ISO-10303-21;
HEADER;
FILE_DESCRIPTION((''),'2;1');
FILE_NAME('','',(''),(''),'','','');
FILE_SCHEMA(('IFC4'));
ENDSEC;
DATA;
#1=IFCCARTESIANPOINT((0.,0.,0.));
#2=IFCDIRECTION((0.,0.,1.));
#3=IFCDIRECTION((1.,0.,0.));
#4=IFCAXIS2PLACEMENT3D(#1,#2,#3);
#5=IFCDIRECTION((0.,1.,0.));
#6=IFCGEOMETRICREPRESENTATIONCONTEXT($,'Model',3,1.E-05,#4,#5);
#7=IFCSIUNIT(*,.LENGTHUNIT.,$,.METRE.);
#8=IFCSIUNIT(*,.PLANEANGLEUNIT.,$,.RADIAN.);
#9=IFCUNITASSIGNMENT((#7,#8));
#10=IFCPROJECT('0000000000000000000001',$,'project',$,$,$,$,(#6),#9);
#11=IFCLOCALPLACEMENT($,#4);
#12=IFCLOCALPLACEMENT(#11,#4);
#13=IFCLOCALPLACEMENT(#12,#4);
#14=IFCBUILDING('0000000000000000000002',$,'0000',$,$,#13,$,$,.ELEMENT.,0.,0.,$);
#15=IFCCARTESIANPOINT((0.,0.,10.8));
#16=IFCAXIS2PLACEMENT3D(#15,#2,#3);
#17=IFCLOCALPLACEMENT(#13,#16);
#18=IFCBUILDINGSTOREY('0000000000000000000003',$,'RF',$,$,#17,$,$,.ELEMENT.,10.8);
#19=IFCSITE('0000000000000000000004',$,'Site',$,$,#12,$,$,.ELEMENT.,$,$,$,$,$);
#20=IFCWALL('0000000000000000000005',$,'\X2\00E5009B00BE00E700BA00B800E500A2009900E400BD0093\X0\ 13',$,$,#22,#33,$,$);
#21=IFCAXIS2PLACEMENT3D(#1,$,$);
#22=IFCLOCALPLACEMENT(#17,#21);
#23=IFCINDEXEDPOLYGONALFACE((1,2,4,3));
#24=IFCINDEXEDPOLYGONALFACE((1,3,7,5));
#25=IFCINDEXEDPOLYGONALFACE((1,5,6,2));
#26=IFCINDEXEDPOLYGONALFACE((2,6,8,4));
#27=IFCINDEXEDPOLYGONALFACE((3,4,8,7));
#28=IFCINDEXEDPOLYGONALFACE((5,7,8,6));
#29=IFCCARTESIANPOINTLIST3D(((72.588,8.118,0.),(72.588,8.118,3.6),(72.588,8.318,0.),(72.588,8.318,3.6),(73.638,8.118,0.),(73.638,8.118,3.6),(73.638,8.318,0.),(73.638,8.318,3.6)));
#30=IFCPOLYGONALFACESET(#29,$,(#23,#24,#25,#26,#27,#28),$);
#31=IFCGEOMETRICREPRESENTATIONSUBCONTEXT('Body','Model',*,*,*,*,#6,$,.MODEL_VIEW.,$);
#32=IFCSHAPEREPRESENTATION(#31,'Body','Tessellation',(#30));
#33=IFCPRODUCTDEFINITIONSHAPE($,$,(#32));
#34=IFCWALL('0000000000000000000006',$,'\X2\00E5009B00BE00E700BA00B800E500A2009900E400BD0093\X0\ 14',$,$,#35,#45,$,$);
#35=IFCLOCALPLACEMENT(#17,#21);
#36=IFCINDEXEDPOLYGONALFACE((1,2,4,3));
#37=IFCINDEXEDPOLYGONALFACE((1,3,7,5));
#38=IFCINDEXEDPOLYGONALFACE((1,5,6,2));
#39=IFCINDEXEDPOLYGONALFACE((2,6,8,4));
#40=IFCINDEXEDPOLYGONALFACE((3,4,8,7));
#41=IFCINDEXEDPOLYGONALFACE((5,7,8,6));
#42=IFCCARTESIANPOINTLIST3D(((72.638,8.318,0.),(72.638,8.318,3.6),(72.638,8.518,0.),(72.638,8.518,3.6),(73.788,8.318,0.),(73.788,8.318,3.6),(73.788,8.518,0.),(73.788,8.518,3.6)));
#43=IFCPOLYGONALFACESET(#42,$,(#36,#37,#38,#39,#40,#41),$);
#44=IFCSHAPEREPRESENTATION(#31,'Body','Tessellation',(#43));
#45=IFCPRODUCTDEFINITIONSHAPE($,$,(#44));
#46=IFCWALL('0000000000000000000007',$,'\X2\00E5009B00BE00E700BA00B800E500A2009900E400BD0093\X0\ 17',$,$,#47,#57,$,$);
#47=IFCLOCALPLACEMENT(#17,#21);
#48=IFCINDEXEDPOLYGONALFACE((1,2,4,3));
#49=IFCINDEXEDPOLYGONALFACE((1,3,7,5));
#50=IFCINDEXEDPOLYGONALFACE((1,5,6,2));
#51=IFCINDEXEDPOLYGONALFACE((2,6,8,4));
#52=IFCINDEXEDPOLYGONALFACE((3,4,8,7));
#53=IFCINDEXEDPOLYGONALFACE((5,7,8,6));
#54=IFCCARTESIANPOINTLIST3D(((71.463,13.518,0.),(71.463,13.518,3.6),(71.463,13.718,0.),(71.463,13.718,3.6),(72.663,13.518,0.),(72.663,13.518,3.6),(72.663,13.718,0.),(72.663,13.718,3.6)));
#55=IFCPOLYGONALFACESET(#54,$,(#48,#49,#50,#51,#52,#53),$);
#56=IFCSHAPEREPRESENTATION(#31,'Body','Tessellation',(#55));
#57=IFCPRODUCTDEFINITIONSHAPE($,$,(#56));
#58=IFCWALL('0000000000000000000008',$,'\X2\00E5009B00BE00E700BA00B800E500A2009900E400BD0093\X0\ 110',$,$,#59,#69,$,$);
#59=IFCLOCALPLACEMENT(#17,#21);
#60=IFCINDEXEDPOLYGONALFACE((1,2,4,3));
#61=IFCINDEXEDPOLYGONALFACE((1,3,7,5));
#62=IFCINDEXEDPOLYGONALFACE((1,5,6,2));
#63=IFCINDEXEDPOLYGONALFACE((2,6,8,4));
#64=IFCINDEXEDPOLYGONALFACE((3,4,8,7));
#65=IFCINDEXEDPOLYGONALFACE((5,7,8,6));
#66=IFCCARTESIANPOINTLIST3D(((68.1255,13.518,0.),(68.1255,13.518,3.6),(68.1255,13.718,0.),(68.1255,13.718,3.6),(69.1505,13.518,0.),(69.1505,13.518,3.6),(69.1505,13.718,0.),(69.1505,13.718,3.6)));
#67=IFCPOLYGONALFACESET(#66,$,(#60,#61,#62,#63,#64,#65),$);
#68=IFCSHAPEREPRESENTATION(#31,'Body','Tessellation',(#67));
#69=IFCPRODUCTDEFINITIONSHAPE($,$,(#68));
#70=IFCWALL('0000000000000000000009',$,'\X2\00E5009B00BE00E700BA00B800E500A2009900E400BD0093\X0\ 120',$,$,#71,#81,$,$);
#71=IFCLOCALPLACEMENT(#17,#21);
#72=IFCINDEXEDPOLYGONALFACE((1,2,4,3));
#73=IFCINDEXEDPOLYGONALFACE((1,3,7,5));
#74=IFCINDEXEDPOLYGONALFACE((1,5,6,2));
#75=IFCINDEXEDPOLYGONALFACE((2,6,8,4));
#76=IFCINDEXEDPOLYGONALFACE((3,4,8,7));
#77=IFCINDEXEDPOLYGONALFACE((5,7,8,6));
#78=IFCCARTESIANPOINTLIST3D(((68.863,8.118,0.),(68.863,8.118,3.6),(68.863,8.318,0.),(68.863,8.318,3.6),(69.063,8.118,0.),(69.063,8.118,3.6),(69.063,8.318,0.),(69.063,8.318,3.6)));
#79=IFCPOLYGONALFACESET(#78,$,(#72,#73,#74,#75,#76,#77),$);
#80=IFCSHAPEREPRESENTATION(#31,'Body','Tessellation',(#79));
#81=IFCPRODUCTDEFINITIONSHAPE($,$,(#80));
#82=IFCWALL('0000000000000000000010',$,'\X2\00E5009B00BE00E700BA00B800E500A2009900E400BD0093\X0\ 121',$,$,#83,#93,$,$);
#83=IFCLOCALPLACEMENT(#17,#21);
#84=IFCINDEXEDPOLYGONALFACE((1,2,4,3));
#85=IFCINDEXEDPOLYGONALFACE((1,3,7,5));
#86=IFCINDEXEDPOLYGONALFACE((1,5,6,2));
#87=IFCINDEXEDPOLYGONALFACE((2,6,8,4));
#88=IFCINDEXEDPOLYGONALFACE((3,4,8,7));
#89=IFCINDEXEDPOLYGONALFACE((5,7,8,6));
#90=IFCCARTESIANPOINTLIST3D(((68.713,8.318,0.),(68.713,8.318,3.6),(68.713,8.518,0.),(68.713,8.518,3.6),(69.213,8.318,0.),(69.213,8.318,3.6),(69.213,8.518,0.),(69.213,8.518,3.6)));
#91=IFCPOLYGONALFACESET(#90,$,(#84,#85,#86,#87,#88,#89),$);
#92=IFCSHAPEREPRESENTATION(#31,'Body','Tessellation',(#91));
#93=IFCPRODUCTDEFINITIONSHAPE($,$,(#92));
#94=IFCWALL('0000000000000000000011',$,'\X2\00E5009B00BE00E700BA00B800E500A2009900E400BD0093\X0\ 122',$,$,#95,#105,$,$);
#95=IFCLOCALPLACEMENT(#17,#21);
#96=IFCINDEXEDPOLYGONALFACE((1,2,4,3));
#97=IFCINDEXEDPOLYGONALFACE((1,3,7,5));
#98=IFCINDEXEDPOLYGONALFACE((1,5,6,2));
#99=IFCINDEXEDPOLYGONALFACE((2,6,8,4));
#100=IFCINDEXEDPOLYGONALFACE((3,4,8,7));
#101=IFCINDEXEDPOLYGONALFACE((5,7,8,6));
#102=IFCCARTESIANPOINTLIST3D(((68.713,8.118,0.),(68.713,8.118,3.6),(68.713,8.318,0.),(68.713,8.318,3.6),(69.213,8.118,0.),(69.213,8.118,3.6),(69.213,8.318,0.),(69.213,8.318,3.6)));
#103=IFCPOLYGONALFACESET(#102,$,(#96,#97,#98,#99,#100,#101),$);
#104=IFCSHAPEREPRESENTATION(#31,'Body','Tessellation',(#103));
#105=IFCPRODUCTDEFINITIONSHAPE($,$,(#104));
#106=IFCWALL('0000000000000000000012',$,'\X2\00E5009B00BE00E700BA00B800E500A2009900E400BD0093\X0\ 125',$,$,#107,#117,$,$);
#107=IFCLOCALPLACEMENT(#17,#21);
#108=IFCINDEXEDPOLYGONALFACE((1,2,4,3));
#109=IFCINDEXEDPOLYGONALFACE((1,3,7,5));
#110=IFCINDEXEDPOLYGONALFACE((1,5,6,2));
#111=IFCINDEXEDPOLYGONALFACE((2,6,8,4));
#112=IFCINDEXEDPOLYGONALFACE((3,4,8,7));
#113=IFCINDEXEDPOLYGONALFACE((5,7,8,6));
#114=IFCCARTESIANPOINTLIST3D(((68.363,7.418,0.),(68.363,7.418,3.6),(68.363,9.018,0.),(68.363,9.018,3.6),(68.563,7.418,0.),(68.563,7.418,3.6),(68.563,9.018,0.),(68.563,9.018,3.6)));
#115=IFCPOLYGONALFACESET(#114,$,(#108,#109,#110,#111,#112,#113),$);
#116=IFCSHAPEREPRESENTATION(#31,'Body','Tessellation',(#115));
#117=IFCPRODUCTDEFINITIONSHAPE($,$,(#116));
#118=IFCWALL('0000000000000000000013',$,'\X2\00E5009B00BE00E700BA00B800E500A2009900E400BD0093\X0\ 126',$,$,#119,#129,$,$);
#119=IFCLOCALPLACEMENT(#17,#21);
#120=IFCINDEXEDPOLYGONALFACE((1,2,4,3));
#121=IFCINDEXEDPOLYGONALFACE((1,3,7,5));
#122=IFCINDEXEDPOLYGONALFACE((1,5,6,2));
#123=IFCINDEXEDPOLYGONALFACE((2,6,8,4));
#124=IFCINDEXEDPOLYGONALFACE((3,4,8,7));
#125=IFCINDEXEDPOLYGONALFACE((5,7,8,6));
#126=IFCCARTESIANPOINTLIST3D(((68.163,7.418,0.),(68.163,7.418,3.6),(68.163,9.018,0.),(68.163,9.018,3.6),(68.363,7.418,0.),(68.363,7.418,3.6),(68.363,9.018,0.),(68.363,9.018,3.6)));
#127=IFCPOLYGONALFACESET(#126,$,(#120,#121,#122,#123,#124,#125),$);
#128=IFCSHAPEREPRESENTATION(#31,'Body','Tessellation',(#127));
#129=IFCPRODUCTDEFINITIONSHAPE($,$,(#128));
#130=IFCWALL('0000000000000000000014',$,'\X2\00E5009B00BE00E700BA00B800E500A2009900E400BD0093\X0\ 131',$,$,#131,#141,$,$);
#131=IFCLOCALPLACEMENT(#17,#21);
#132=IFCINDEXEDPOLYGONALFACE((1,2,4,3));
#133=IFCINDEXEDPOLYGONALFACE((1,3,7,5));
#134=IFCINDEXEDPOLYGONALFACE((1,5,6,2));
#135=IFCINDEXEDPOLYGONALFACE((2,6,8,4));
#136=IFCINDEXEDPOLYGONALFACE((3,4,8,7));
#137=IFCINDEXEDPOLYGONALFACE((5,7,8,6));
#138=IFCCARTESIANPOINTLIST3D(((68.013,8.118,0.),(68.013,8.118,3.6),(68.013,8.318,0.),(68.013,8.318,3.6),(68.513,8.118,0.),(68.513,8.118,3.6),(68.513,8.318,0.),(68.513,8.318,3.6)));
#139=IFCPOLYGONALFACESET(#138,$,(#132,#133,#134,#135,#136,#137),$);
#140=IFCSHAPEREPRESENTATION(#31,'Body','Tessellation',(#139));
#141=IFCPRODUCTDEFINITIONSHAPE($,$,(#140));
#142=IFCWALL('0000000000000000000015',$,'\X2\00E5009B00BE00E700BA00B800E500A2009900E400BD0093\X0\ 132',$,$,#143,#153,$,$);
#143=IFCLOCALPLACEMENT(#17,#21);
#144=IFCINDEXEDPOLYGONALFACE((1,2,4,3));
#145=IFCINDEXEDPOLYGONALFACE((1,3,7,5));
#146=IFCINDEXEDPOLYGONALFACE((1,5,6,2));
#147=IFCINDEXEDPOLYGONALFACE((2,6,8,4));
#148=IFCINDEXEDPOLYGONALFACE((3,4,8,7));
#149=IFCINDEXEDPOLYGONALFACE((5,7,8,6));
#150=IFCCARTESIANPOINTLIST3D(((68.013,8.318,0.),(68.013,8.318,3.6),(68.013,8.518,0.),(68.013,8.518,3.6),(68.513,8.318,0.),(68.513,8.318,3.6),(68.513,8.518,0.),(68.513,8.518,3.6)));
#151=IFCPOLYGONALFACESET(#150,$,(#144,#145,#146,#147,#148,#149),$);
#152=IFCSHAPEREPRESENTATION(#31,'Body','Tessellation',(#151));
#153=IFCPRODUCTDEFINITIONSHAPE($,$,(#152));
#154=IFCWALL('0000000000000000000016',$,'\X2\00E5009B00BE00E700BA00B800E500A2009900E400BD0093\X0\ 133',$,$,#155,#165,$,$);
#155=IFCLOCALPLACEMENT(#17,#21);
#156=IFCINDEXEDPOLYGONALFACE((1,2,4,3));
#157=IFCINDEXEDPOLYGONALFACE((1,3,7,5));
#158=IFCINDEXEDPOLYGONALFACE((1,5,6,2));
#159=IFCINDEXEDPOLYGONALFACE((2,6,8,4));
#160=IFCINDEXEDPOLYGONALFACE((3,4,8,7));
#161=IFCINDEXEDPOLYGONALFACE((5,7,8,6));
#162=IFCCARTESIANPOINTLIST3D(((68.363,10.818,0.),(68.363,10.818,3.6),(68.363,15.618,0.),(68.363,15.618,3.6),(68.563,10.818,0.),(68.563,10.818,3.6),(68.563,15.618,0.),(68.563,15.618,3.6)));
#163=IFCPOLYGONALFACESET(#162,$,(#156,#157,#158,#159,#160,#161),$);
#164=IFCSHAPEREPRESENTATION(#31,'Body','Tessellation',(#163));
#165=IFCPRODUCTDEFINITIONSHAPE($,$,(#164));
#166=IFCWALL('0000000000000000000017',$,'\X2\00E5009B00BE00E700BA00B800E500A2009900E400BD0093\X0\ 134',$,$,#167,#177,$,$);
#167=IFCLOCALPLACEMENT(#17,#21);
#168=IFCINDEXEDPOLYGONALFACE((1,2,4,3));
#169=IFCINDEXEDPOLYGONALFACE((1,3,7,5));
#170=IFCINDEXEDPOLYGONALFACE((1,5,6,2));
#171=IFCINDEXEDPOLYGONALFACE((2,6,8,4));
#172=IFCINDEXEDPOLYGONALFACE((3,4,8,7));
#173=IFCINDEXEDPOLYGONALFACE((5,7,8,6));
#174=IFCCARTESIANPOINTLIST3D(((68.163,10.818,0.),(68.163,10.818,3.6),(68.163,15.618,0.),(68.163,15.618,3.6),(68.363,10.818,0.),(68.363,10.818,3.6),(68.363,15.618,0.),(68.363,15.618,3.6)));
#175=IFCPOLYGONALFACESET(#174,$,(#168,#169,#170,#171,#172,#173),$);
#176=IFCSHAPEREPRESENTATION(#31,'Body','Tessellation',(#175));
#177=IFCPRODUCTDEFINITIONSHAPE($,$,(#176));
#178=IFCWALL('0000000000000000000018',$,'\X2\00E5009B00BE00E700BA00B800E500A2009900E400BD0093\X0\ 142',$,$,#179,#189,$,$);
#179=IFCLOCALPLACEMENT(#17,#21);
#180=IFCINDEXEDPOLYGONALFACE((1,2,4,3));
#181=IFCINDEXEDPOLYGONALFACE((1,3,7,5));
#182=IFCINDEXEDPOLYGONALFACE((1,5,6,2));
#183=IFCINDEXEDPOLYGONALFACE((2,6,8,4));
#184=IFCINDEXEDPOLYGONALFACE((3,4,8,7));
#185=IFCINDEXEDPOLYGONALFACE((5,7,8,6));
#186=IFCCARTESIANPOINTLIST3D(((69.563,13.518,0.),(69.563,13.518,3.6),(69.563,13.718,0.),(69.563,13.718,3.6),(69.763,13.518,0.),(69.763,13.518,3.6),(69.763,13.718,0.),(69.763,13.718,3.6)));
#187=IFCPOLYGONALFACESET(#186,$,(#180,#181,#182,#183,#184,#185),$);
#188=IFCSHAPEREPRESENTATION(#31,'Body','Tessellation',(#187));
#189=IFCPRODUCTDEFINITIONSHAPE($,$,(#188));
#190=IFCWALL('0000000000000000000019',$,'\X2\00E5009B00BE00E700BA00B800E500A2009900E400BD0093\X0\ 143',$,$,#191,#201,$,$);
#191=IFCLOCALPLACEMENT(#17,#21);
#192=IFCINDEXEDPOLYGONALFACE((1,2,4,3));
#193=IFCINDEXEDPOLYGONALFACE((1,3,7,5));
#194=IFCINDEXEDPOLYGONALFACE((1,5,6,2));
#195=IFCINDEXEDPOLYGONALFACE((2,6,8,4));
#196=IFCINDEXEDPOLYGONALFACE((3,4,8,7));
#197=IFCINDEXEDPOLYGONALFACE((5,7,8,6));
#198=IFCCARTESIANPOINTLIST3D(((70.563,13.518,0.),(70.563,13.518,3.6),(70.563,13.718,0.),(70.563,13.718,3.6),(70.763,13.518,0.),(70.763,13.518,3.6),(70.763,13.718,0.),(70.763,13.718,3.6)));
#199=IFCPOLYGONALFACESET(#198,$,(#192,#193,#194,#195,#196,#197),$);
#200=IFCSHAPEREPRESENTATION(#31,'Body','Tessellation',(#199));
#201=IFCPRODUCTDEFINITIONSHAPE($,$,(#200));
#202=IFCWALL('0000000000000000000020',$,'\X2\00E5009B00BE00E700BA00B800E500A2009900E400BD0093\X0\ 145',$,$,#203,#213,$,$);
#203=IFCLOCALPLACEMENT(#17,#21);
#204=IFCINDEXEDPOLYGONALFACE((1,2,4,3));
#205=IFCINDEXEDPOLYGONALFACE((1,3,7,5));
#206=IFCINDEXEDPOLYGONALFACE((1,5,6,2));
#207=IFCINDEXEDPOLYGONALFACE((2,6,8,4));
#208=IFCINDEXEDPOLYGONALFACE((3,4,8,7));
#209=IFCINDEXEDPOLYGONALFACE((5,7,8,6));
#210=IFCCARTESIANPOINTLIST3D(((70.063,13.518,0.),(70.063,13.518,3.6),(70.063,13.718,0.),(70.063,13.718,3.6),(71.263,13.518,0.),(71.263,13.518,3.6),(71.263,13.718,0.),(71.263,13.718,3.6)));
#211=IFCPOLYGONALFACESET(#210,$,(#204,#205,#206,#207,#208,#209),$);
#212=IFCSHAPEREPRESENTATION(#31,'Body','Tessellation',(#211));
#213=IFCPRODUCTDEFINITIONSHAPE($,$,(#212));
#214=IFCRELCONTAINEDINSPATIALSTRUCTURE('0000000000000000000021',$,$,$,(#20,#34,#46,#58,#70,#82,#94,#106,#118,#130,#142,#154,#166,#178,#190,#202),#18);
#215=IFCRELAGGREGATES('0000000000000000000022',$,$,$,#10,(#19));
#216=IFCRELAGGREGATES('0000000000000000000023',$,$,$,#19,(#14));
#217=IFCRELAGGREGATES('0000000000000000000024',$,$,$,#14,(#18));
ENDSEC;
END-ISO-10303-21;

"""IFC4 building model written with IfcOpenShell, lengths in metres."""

from ifc_helpers import new_model, si_unit, direction, frame, frame_2d, origin_with_axes, place, context, subcontext, project, spatial, rectangle, extrude, element, save


model = new_model("IFC4")

# Units and contexts
model_context = context("Model", 3, precision=1e-05, world=origin_with_axes(), true_north=direction((0.0, 1.0, 0.0)))
body_context = subcontext(model_context, "Body", "Model", "MODEL_VIEW")
ifc_project = project(units=[si_unit("LENGTHUNIT", "METRE"), si_unit("PLANEANGLEUNIT", "RADIAN")], contexts=[model_context])

# Site, building, storey
placement = place(None, origin_with_axes())
site_placement = place(placement, origin_with_axes())
site = spatial("IfcSite", under=ifc_project, at=site_placement, Name="Site", CompositionType="ELEMENT")
building_placement = place(site_placement, origin_with_axes())
building = spatial("IfcBuilding", under=site, at=building_placement, Name="0000", CompositionType="ELEMENT", ElevationOfRefHeight=0.0, ElevationOfTerrain=0.0)
storey_placement = place(building_placement, frame((0.0, 0.0, 10.8), z_axis=(0.0, 0.0, 1.0), x_axis=(1.0, 0.0, 0.0)))
storey = spatial("IfcBuildingStorey", under=building, at=storey_placement, Name="RF", CompositionType="ELEMENT", Elevation=10.8)

# Walls
wall_1_placement = place(storey_placement, frame((73.113, 8.218, 0.0), z_axis=(0.0, 0.0, 1.0), x_axis=(-1.0, 0.0, 0.0)))
element("IfcWall", 1, at=wall_1_placement, inside=storey, Name="å\u009b¾çº¸å¢\u0099ä½\u0093 13", context=body_context, shape_type="SweptSolid", body=[
    extrude(rectangle(XDim=1.05, YDim=0.2, at=frame_2d((0.0, 0.0), x_axis=(1.0, 0.0, 0.0))), frame((0.0, 0.0, 0.0), z_axis=(0.0, 0.0, 1.0)), (0.0, 0.0, 1.0), 3.6),
])
wall_2_placement = place(storey_placement, frame((73.213, 8.418, 0.0), z_axis=(0.0, 0.0, 1.0), x_axis=(-1.0, 0.0, 0.0)))
element("IfcWall", 2, at=wall_2_placement, inside=storey, Name="å\u009b¾çº¸å¢\u0099ä½\u0093 14", context=body_context, shape_type="SweptSolid", body=[
    extrude(rectangle(XDim=1.15, YDim=0.2, at=frame_2d((0.0, 0.0), x_axis=(1.0, 0.0, 0.0))), frame((0.0, 0.0, 0.0), z_axis=(0.0, 0.0, 1.0)), (0.0, 0.0, 1.0), 3.6),
])
wall_3_placement = place(storey_placement, frame((72.063, 13.618, 0.0), z_axis=(0.0, 0.0, 1.0), x_axis=(1.0, 0.0, 0.0)))
element("IfcWall", 3, at=wall_3_placement, inside=storey, Name="å\u009b¾çº¸å¢\u0099ä½\u0093 17", context=body_context, shape_type="SweptSolid", body=[
    extrude(rectangle(XDim=1.2, YDim=0.2, at=frame_2d((0.0, 0.0), x_axis=(1.0, 0.0, 0.0))), frame((0.0, 0.0, 0.0), z_axis=(0.0, 0.0, 1.0)), (0.0, 0.0, 1.0), 3.6),
])
wall_4_placement = place(storey_placement, frame((68.638, 13.618, 0.0), z_axis=(0.0, 0.0, 1.0), x_axis=(1.0, 0.0, 0.0)))
element("IfcWall", 4, at=wall_4_placement, inside=storey, Name="å\u009b¾çº¸å¢\u0099ä½\u0093 110", context=body_context, shape_type="SweptSolid", body=[
    extrude(rectangle(XDim=1.025, YDim=0.2, at=frame_2d((0.0, 0.0), x_axis=(1.0, 0.0, 0.0))), frame((0.0, 0.0, 0.0), z_axis=(0.0, 0.0, 1.0)), (0.0, 0.0, 1.0), 3.6),
])
wall_5_placement = place(storey_placement, frame((68.963, 8.218, 0.0), z_axis=(0.0, 0.0, 1.0), x_axis=(0.0, 1.0, 0.0)))
element("IfcWall", 5, at=wall_5_placement, inside=storey, Name="å\u009b¾çº¸å¢\u0099ä½\u0093 120", context=body_context, shape_type="SweptSolid", body=[
    extrude(rectangle(XDim=0.2, YDim=0.2, at=frame_2d((0.0, 0.0), x_axis=(1.0, 0.0, 0.0))), frame((0.0, 0.0, 0.0), z_axis=(0.0, 0.0, 1.0)), (0.0, 0.0, 1.0), 3.6),
])
for number, where, z_axis, x_axis, name in (
    (6, (68.963, 8.418, 0.0), (0.0, 0.0, 1.0), (-1.0, 0.0, 0.0), "å\u009b¾çº¸å¢\u0099ä½\u0093 121"),
    (7, (68.963, 8.218, 0.0), (0.0, 0.0, 1.0), (-1.0, 0.0, 0.0), "å\u009b¾çº¸å¢\u0099ä½\u0093 122"),
):
    element("IfcWall", number, at=place(storey_placement, frame(where, z_axis=z_axis, x_axis=x_axis)), inside=storey, Name=name, context=body_context, shape_type="SweptSolid", body=[
        extrude(rectangle(XDim=0.5, YDim=0.2, at=frame_2d((0.0, 0.0), x_axis=(1.0, 0.0, 0.0))), frame((0.0, 0.0, 0.0), z_axis=(0.0, 0.0, 1.0)), (0.0, 0.0, 1.0), 3.6),
    ])
for number, where, z_axis, x_axis, name in (
    (8, (68.463, 8.218, 0.0), (0.0, 0.0, 1.0), (0.0, -1.0, 0.0), "å\u009b¾çº¸å¢\u0099ä½\u0093 125"),
    (9, (68.263, 8.218, 0.0), (0.0, 0.0, 1.0), (0.0, -1.0, 0.0), "å\u009b¾çº¸å¢\u0099ä½\u0093 126"),
):
    element("IfcWall", number, at=place(storey_placement, frame(where, z_axis=z_axis, x_axis=x_axis)), inside=storey, Name=name, context=body_context, shape_type="SweptSolid", body=[
        extrude(rectangle(XDim=1.6, YDim=0.2, at=frame_2d((0.0, 0.0), x_axis=(1.0, 0.0, 0.0))), frame((0.0, 0.0, 0.0), z_axis=(0.0, 0.0, 1.0)), (0.0, 0.0, 1.0), 3.6),
    ])
for number, where, z_axis, x_axis, name in (
    (10, (68.263, 8.218, 0.0), (0.0, 0.0, 1.0), (-1.0, 0.0, 0.0), "å\u009b¾çº¸å¢\u0099ä½\u0093 131"),
    (11, (68.263, 8.418, 0.0), (0.0, 0.0, 1.0), (-1.0, 0.0, 0.0), "å\u009b¾çº¸å¢\u0099ä½\u0093 132"),
):
    element("IfcWall", number, at=place(storey_placement, frame(where, z_axis=z_axis, x_axis=x_axis)), inside=storey, Name=name, context=body_context, shape_type="SweptSolid", body=[
        extrude(rectangle(XDim=0.5, YDim=0.2, at=frame_2d((0.0, 0.0), x_axis=(1.0, 0.0, 0.0))), frame((0.0, 0.0, 0.0), z_axis=(0.0, 0.0, 1.0)), (0.0, 0.0, 1.0), 3.6),
    ])
for number, where, z_axis, x_axis, name in (
    (12, (68.463, 13.218, 0.0), (0.0, 0.0, 1.0), (0.0, -1.0, 0.0), "å\u009b¾çº¸å¢\u0099ä½\u0093 133"),
    (13, (68.263, 13.218, 0.0), (0.0, 0.0, 1.0), (0.0, -1.0, 0.0), "å\u009b¾çº¸å¢\u0099ä½\u0093 134"),
):
    element("IfcWall", number, at=place(storey_placement, frame(where, z_axis=z_axis, x_axis=x_axis)), inside=storey, Name=name, context=body_context, shape_type="SweptSolid", body=[
        extrude(rectangle(XDim=4.8, YDim=0.2, at=frame_2d((0.0, 0.0), x_axis=(1.0, 0.0, 0.0))), frame((0.0, 0.0, 0.0), z_axis=(0.0, 0.0, 1.0)), (0.0, 0.0, 1.0), 3.6),
    ])
for number, where, z_axis, x_axis, name in (
    (14, (69.663, 13.618, 0.0), (0.0, 0.0, 1.0), (0.0, 1.0, 0.0), "å\u009b¾çº¸å¢\u0099ä½\u0093 142"),
    (15, (70.663, 13.618, 0.0), (0.0, 0.0, 1.0), (0.0, 1.0, 0.0), "å\u009b¾çº¸å¢\u0099ä½\u0093 143"),
):
    element("IfcWall", number, at=place(storey_placement, frame(where, z_axis=z_axis, x_axis=x_axis)), inside=storey, Name=name, context=body_context, shape_type="SweptSolid", body=[
        extrude(rectangle(XDim=0.2, YDim=0.2, at=frame_2d((0.0, 0.0), x_axis=(1.0, 0.0, 0.0))), frame((0.0, 0.0, 0.0), z_axis=(0.0, 0.0, 1.0)), (0.0, 0.0, 1.0), 3.6),
    ])
wall_6_placement = place(storey_placement, frame((70.663, 13.618, 0.0), z_axis=(0.0, 0.0, 1.0), x_axis=(1.0, 0.0, 0.0)))
element("IfcWall", 16, at=wall_6_placement, inside=storey, Name="å\u009b¾çº¸å¢\u0099ä½\u0093 145", context=body_context, shape_type="SweptSolid", body=[
    extrude(rectangle(XDim=1.2, YDim=0.2, at=frame_2d((0.0, 0.0), x_axis=(1.0, 0.0, 0.0))), frame((0.0, 0.0, 0.0), z_axis=(0.0, 0.0, 1.0)), (0.0, 0.0, 1.0), 3.6),
])

save(model, "model.ifc")
